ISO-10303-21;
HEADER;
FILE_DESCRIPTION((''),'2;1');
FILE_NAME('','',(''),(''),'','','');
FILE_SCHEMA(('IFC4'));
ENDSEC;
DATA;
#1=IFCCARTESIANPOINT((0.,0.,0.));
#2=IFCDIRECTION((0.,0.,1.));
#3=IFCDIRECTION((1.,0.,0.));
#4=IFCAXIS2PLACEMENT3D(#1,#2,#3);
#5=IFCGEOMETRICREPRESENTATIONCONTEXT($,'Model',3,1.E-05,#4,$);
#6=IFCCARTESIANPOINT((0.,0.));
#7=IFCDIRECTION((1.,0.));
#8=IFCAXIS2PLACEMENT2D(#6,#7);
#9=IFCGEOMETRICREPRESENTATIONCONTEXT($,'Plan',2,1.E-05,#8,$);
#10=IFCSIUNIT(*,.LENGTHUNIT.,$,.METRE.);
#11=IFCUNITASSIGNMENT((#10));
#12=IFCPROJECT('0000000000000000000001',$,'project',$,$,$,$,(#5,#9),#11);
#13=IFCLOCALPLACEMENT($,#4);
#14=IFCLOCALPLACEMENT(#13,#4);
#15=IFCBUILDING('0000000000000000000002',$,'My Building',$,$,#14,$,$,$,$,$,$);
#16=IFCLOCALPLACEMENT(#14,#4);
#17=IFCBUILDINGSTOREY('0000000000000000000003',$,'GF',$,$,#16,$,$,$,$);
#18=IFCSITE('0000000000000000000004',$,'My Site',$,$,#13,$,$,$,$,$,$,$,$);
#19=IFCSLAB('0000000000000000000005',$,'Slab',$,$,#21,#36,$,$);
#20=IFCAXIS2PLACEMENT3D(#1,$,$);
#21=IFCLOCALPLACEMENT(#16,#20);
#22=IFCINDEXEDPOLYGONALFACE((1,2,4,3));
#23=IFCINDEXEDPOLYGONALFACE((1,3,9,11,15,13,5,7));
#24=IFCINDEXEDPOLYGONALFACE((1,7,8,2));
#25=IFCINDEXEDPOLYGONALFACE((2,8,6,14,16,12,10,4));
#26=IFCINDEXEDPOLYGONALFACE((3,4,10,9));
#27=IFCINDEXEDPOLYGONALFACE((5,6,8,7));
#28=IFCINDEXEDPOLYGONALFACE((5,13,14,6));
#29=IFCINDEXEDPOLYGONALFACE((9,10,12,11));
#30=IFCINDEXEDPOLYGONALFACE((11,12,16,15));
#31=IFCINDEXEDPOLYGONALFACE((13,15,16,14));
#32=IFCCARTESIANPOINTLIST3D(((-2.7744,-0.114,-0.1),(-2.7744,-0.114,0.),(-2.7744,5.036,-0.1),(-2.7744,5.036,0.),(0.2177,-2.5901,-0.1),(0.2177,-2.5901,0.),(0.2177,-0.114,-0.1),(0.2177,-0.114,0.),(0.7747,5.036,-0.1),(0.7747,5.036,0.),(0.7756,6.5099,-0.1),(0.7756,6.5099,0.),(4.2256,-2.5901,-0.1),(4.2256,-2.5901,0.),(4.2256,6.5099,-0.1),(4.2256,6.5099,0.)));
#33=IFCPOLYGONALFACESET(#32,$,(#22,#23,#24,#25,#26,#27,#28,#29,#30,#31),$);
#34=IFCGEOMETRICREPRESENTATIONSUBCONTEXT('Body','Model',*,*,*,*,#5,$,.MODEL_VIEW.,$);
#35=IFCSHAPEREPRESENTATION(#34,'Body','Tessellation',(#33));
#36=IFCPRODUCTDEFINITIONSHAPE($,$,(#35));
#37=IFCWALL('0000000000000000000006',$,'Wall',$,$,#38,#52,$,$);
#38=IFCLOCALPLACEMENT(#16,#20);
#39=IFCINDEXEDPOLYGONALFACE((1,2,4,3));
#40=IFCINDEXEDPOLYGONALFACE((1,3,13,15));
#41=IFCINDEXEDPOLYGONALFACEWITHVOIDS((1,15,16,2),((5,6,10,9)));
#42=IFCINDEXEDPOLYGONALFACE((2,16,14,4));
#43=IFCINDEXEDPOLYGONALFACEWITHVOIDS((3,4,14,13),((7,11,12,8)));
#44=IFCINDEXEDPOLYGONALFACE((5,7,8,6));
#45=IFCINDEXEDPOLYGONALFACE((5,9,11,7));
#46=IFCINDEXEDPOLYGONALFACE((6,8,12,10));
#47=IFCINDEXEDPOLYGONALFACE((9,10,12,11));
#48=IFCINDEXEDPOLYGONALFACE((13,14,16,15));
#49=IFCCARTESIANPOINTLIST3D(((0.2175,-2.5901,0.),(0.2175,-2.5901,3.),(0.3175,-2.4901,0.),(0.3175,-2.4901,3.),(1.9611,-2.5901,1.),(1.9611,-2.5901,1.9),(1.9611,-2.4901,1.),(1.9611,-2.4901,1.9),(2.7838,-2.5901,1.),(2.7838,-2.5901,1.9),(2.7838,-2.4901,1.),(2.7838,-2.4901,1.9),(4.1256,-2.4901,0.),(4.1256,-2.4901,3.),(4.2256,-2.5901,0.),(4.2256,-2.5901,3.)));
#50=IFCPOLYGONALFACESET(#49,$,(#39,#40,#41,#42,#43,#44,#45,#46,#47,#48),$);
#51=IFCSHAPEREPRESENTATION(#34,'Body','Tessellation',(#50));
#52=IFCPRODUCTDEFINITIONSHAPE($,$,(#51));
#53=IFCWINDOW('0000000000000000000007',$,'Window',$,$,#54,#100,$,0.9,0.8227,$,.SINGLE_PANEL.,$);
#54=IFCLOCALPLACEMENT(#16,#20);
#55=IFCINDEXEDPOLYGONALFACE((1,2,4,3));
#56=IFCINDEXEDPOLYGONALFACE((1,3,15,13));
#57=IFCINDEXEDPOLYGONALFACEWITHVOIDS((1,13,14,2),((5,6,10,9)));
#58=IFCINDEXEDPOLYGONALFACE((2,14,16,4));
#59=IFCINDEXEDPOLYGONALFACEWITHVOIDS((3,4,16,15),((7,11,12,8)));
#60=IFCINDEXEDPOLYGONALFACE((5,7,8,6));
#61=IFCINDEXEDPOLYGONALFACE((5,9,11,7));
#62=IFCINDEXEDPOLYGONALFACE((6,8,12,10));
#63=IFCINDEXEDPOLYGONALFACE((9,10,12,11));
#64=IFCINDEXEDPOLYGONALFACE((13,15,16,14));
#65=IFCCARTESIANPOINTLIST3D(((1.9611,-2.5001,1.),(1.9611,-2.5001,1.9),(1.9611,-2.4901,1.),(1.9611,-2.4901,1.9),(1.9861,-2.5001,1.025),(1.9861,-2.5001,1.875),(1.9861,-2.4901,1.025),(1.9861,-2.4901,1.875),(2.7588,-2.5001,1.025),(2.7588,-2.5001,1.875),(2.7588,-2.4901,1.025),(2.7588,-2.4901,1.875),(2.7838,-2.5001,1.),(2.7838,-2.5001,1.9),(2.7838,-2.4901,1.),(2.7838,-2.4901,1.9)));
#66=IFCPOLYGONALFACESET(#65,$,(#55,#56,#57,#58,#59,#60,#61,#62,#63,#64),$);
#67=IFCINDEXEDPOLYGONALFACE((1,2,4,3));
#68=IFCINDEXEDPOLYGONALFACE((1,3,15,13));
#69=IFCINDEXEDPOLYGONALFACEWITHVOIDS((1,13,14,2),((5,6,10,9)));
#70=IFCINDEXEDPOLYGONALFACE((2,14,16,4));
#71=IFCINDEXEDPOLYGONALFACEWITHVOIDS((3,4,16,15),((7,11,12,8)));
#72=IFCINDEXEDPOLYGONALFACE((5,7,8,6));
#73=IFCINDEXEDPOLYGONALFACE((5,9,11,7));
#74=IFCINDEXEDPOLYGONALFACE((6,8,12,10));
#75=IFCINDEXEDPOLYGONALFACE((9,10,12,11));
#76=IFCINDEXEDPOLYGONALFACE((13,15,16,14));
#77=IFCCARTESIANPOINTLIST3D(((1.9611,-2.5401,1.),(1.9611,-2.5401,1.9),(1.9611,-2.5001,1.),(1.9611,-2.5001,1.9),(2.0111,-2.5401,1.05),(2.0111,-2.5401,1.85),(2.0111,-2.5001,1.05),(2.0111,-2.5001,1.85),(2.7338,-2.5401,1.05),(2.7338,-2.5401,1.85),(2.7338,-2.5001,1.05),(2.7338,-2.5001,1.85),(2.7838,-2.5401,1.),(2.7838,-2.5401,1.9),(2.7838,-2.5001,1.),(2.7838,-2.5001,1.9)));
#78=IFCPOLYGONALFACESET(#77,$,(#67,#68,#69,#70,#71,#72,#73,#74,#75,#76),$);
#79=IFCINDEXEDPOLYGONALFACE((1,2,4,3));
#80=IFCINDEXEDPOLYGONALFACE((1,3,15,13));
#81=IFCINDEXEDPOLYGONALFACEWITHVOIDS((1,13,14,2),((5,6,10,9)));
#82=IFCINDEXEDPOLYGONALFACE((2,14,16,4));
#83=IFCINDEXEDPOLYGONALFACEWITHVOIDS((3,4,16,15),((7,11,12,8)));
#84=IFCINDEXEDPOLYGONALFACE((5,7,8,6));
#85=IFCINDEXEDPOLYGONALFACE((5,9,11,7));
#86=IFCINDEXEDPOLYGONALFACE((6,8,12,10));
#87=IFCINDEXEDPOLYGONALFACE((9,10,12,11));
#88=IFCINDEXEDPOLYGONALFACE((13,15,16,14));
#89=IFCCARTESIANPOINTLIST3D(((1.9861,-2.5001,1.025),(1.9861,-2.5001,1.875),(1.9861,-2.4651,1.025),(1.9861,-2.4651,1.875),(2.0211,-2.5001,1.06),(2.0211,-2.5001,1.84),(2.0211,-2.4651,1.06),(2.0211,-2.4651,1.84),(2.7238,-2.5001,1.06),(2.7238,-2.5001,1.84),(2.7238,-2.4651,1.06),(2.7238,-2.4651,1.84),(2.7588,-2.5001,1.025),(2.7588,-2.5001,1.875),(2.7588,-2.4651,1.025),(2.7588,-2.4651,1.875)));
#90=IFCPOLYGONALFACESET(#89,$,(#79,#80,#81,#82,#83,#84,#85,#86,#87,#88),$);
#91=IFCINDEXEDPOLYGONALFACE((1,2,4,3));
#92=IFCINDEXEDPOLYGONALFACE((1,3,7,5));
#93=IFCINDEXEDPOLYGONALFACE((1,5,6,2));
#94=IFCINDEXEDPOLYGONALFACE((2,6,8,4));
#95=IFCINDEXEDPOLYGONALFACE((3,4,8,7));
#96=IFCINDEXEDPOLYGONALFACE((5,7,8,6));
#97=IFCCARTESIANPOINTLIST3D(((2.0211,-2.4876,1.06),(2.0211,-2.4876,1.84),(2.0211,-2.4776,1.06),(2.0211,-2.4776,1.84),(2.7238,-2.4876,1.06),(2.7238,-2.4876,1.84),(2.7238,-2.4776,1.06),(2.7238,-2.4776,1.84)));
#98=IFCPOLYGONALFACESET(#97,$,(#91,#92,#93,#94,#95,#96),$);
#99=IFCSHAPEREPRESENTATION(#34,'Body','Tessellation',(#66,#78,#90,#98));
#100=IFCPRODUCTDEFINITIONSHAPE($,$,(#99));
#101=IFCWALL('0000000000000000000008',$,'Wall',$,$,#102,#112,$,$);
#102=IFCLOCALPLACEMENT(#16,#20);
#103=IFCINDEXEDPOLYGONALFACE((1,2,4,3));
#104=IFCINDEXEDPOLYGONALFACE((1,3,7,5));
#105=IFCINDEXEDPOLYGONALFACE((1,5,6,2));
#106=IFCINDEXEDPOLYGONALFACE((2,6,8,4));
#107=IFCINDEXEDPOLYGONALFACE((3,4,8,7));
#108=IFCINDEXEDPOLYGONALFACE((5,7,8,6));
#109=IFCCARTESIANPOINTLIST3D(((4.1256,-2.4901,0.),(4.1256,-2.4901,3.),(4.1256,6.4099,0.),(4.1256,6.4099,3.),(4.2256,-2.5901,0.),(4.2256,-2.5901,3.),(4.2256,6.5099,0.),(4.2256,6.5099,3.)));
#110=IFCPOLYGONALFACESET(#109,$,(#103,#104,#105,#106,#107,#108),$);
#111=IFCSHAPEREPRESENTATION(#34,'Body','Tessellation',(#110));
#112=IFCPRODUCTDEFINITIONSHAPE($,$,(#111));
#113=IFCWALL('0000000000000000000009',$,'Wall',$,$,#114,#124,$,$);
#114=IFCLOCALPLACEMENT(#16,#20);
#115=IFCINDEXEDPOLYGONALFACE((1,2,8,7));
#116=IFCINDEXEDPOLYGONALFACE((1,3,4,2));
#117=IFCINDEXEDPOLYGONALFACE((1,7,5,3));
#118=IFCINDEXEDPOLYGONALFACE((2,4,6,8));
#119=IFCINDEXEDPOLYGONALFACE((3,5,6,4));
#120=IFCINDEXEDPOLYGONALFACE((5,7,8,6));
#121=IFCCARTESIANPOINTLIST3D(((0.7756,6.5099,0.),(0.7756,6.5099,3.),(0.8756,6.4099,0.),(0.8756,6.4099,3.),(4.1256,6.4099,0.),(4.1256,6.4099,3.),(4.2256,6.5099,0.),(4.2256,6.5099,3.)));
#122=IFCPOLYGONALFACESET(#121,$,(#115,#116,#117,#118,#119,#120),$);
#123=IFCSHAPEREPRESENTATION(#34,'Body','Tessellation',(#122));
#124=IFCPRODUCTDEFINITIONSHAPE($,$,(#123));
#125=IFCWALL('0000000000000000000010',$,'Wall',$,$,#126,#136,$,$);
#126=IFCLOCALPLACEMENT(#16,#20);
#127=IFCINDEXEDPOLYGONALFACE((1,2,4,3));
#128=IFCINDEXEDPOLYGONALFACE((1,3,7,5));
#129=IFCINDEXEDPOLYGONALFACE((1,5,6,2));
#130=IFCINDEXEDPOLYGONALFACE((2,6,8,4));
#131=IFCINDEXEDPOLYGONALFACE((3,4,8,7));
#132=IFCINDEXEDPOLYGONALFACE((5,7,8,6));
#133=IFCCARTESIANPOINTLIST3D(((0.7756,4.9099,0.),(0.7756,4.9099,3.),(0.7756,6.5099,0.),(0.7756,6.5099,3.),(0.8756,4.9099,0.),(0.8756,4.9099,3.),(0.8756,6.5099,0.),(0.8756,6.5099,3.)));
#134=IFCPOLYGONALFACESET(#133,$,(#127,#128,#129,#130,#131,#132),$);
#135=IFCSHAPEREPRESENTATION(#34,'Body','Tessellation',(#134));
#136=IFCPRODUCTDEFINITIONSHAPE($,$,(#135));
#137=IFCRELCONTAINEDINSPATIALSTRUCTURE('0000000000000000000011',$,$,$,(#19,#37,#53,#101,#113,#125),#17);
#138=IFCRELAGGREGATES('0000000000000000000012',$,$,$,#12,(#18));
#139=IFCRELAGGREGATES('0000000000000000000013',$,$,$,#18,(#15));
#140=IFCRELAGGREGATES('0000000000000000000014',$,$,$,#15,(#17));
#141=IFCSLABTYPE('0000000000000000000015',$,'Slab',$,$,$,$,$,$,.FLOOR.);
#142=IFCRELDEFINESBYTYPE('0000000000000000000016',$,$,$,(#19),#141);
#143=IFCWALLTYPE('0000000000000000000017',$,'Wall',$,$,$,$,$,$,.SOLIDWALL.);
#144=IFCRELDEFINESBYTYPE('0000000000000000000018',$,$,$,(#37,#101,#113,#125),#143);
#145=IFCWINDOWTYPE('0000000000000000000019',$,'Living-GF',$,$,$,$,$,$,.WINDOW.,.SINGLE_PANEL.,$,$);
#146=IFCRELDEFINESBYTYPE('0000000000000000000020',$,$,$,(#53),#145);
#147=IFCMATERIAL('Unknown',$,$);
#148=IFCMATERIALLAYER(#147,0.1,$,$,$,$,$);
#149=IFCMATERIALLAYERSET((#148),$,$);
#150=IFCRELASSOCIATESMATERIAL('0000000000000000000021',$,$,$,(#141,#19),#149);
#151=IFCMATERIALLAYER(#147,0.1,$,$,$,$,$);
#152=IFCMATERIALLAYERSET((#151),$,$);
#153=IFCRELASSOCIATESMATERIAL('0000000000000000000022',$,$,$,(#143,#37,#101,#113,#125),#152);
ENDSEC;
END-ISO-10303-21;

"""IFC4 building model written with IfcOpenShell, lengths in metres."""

from ifc_helpers import new_model, entity, si_unit, frame, origin_with_axes, origin_2d_with_axis, place, context, subcontext, project, spatial, line, indexed_curve, outline, extrude, shape, source, transform, mapped, material, layer, layer_set, layer_usage, type_object, type_shapes, element, fill, save


model = new_model("IFC4")

# Units and contexts
model_context = context("Model", 3, precision=1e-05, world=origin_with_axes())
plan_context = context("Plan", 2, precision=1e-05, world=origin_2d_with_axis())
body_context_1 = subcontext(model_context, "Body", "Model", "MODEL_VIEW")
body_context_2 = subcontext(plan_context, "Body", "Plan", "PLAN_VIEW")
ifc_project = project(units=[si_unit("LENGTHUNIT", "METRE")], contexts=[model_context, plan_context])

# Site, building, storey
site_placement = place(None, origin_with_axes())
site = spatial("IfcSite", under=ifc_project, at=site_placement, Name="My Site")
building_placement = place(site_placement, origin_with_axes())
building = spatial("IfcBuilding", under=site, at=building_placement, Name="My Building")
storey_placement = place(building_placement, origin_with_axes())
storey = spatial("IfcBuildingStorey", under=building, at=storey_placement, Name="GF")

# Slab
ifc_material = material(Name="Unknown")
ifc_layer_1 = layer(ifc_material, 0.1)
ifc_layer_set_1 = layer_set([ifc_layer_1])
ifc_layer_usage_1 = layer_usage(ifc_layer_set_1, "AXIS3", "POSITIVE", -0.1)
slab_type = type_object("IfcSlabType", Name="Slab", PredefinedType="FLOOR", material=ifc_layer_set_1)
slab_placement = place(storey_placement, frame((4.2256, -2.5901, 0.0), z_axis=(0.0, 0.0, 1.0), x_axis=(1.0, 0.0, 0.0)))
element("IfcSlab", 1, at=slab_placement, inside=storey, type_object=slab_type, material=ifc_layer_usage_1, Name="Slab", context=body_context_1, shape_type="SweptSolid", body=[
    extrude(outline(indexed_curve([(0.0, 0.0), (0.0, 9.1), (-3.45, 9.1), (-3.4508, 7.6261), (-7.0, 7.6261), (-7.0, 2.4761), (-4.0079, 2.4761), (-4.0079, 0.0), (0.0, 0.0)])), frame((0.0, 0.0, -0.1), z_axis=(0.0, 0.0, 1.0), x_axis=(1.0, 0.0, 0.0)), (0.0, 0.0, 1.0), 0.1),
])

# Wall, opening, window
ifc_layer_2 = layer(ifc_material, 0.1)
ifc_layer_set_2 = layer_set([ifc_layer_2])
ifc_layer_usage_2 = layer_usage(ifc_layer_set_2, "AXIS2", "POSITIVE", 0.0)
wall_type = type_object("IfcWallType", Name="Wall", PredefinedType="SOLIDWALL", material=ifc_layer_set_2)
wall_1_placement = place(storey_placement, frame((0.2175, -2.5901, 0.0), z_axis=(0.0, 0.0, 1.0), x_axis=(1.0, 0.0, 0.0)))
wall_1 = element("IfcWall", 2, at=wall_1_placement, inside=storey, type_object=wall_type, material=ifc_layer_usage_2, Name="Wall", context=body_context_1, shape_type="SweptSolid", body=[
    extrude(outline(indexed_curve([(0.0, 0.0), (0.1, 0.1), (3.9081, 0.1), (4.0081, 0.0)], segments=[line(1, 2, 3, 4, 1)])), origin_with_axes(), (0.0, 0.0, 1.0), 3.0),
])
shared_shape_1 = source(origin_with_axes(), body_context_1, "Body", "SweptSolid", [
    extrude(outline(indexed_curve([(0.0, 0.0), (0.8227, 0.0), (0.8227, 0.9), (0.0, 0.9)], segments=[line(1, 2, 3, 4, 1)])), frame((0.0, -0.6, 0.0), z_axis=(0.0, -1.0, 0.0), x_axis=(1.0, 0.0, 0.0)), (0.0, 0.0, -1.0), 1.2),
])
opening_1_placement = place(wall_1_placement, frame((1.7436, 0.0, 1.0), z_axis=(0.0, 0.0, 1.0), x_axis=(1.0, -0.000001, 0.0)))
opening_1 = element("IfcOpeningElement", 3, at=opening_1_placement, cuts=wall_1, PredefinedType="OPENING", context=body_context_1, shape_type="MappedRepresentation", body=[
    mapped(shared_shape_1, transform((0.0, 0.0, 0.0), x_axis=(1.0, 0.0, 0.0), y_axis=(0.0, 1.0, 0.0), z_axis=(0.0, 0.0, 1.0), scale=1.0)),
])
window_type_1 = type_object("IfcWindowType", Name="Living-GF", PartitioningType="SINGLE_PANEL", PredefinedType="WINDOW")
shared_shape_2 = source(origin_with_axes(), body_context_1, "Body", "SweptSolid", [
    extrude(outline(indexed_curve([(0.0, 0.0), (0.8227, 0.0), (0.8227, 0.9), (0.0, 0.9)], segments=[line(1, 2, 3, 4, 1)]), holes=[indexed_curve([(0.025, 0.025), (0.7977, 0.025), (0.7977, 0.875), (0.025, 0.875)], segments=[line(1, 2, 3, 4, 1)])]), frame((0.0, 0.09, 0.0), z_axis=(0.0, -1.0, 0.0), x_axis=(1.0, 0.0, 0.0)), (0.0, 0.0, -1.0), 0.01),
    extrude(outline(indexed_curve([(0.0, 0.0), (0.8227, 0.0), (0.8227, 0.9), (0.0, 0.9)], segments=[line(1, 2, 3, 4, 1)]), holes=[indexed_curve([(0.05, 0.05), (0.7727, 0.05), (0.7727, 0.85), (0.05, 0.85)], segments=[line(1, 2, 3, 4, 1)])]), frame((0.0, 0.05, 0.0), z_axis=(0.0, -1.0, 0.0), x_axis=(1.0, 0.0, 0.0)), (0.0, 0.0, -1.0), 0.04),
    extrude(outline(indexed_curve([(0.0, 0.0), (0.7727, 0.0), (0.7727, 0.85), (0.0, 0.85)], segments=[line(1, 2, 3, 4, 1)]), holes=[indexed_curve([(0.035, 0.035), (0.7377, 0.035), (0.7377, 0.815), (0.035, 0.815)], segments=[line(1, 2, 3, 4, 1)])]), frame((0.025, 0.09, 0.025), z_axis=(0.0, -1.0, 0.0), x_axis=(1.0, 0.0, 0.0)), (0.0, 0.0, -1.0), 0.035),
    extrude(outline(indexed_curve([(0.035, 0.035), (0.7377, 0.035), (0.7377, 0.815), (0.035, 0.815)], segments=[line(1, 2, 3, 4, 1)])), frame((0.025, 0.1025, 0.025), z_axis=(0.0, -1.0, 0.0), x_axis=(1.0, 0.0, 0.0)), (0.0, 0.0, -1.0), 0.01),
])
shared_shape_3 = source(origin_with_axes(), body_context_2, "Body", "Curve2D", [
    entity("IfcIndexedPolyCurve", entity("IfcCartesianPointList2D", [[0.05, 0.05], [0.7727, 0.05]])),
    entity("IfcIndexedPolyCurve", entity("IfcCartesianPointList2D", [[0.0, 0.1], [0.025, 0.1], [0.025, 0.09], [0.05, 0.09], [0.05, 0.05], [0.0, 0.05]]), [entity("IfcLineIndex", [1, 2, 3, 4, 5, 6, 1])]),
    entity("IfcIndexedPolyCurve", entity("IfcCartesianPointList2D", [[0.8227, 0.1], [0.7977, 0.1], [0.7977, 0.09], [0.7727, 0.09], [0.7727, 0.05], [0.8227, 0.05]]), [entity("IfcLineIndex", [1, 2, 3, 4, 5, 6, 1])]),
    entity("IfcIndexedPolyCurve", entity("IfcCartesianPointList2D", [[0.025, 0.09], [0.06, 0.09], [0.06, 0.125], [0.025, 0.125]]), [entity("IfcLineIndex", [1, 2, 3, 4, 1])]),
    entity("IfcIndexedPolyCurve", entity("IfcCartesianPointList2D", [[0.7977, 0.09], [0.7627, 0.09], [0.7627, 0.125], [0.7977, 0.125]]), [entity("IfcLineIndex", [1, 2, 3, 4, 1])]),
    entity("IfcIndexedPolyCurve", entity("IfcCartesianPointList2D", [[0.06, 0.09], [0.7627, 0.09]])),
    entity("IfcIndexedPolyCurve", entity("IfcCartesianPointList2D", [[0.06, 0.125], [0.7627, 0.125]])),
    entity("IfcIndexedPolyCurve", entity("IfcCartesianPointList2D", [[0.06, 0.1075], [0.7627, 0.1075]])),
])
type_shapes(window_type_1, [shared_shape_2, shared_shape_3])
window_1_placement = place(opening_1_placement, origin_with_axes())
window_1 = element("IfcWindow", 4, at=window_1_placement, inside=storey, type_object=window_type_1, Name="Window", OverallHeight=0.9, OverallWidth=0.8227, PartitioningType="SINGLE_PANEL", shapes=[
    shape(body_context_1, "Body", "MappedRepresentation", [mapped(shared_shape_2, transform((0.0, 0.0, 0.0), x_axis=(1.0, 0.0, 0.0), y_axis=(0.0, 1.0, 0.0), z_axis=(0.0, 0.0, 1.0), scale=1.0))]),
    shape(body_context_2, "Body", "MappedRepresentation", [mapped(shared_shape_3, transform((0.0, 0.0, 0.0), x_axis=(1.0, 0.0, 0.0), y_axis=(0.0, 1.0, 0.0), z_axis=(0.0, 0.0, 1.0), scale=1.0))]),
])
fill(opening_1, window_1)

# Walls
ifc_layer_usage_3 = layer_usage(ifc_layer_set_2, "AXIS2", "POSITIVE", 0.0)
wall_2_placement = place(storey_placement, frame((4.2256, -2.5901, 0.0), z_axis=(0.0, 0.0, 1.0), x_axis=(0.0, 1.0, 0.0)))
element("IfcWall", 5, at=wall_2_placement, inside=storey, type_object=wall_type, material=ifc_layer_usage_3, Name="Wall", context=body_context_1, shape_type="SweptSolid", body=[
    extrude(outline(indexed_curve([(0.0, 0.0), (0.1, 0.1), (9.0, 0.1), (9.1, 0.0)], segments=[line(1, 2, 3, 4, 1)])), origin_with_axes(), (0.0, 0.0, 1.0), 3.0),
])
ifc_layer_usage_4 = layer_usage(ifc_layer_set_2, "AXIS2", "POSITIVE", 0.0)
wall_3_placement = place(storey_placement, frame((4.2256, 6.5099, 0.0), z_axis=(0.0, 0.0, 1.0), x_axis=(-1.0, 0.0, 0.0)))
element("IfcWall", 6, at=wall_3_placement, inside=storey, type_object=wall_type, material=ifc_layer_usage_4, Name="Wall", context=body_context_1, shape_type="SweptSolid", body=[
    extrude(outline(indexed_curve([(0.0, 0.0), (0.1, 0.1), (3.35, 0.1), (3.45, 0.0)], segments=[line(1, 2, 3, 4, 1)])), origin_with_axes(), (0.0, 0.0, 1.0), 3.0),
])
ifc_layer_usage_5 = layer_usage(ifc_layer_set_2, "AXIS2", "POSITIVE", 0.0)
wall_4_placement = place(storey_placement, frame((0.7756, 6.5099, 0.0), z_axis=(0.0, 0.0, 1.0), x_axis=(0.0, -1.0, 0.0)))
element("IfcWall", 7, at=wall_4_placement, inside=storey, type_object=wall_type, material=ifc_layer_usage_5, Name="Wall", context=body_context_1, shape_type="SweptSolid", body=[
    extrude(outline(indexed_curve([(0.0, 0.0), (0.0, 0.1), (1.6, 0.1), (1.6, 0.0)], segments=[line(1, 2, 3, 4, 1)])), origin_with_axes(), (0.0, 0.0, 1.0), 3.0),
])

save(model, "model.ifc")
